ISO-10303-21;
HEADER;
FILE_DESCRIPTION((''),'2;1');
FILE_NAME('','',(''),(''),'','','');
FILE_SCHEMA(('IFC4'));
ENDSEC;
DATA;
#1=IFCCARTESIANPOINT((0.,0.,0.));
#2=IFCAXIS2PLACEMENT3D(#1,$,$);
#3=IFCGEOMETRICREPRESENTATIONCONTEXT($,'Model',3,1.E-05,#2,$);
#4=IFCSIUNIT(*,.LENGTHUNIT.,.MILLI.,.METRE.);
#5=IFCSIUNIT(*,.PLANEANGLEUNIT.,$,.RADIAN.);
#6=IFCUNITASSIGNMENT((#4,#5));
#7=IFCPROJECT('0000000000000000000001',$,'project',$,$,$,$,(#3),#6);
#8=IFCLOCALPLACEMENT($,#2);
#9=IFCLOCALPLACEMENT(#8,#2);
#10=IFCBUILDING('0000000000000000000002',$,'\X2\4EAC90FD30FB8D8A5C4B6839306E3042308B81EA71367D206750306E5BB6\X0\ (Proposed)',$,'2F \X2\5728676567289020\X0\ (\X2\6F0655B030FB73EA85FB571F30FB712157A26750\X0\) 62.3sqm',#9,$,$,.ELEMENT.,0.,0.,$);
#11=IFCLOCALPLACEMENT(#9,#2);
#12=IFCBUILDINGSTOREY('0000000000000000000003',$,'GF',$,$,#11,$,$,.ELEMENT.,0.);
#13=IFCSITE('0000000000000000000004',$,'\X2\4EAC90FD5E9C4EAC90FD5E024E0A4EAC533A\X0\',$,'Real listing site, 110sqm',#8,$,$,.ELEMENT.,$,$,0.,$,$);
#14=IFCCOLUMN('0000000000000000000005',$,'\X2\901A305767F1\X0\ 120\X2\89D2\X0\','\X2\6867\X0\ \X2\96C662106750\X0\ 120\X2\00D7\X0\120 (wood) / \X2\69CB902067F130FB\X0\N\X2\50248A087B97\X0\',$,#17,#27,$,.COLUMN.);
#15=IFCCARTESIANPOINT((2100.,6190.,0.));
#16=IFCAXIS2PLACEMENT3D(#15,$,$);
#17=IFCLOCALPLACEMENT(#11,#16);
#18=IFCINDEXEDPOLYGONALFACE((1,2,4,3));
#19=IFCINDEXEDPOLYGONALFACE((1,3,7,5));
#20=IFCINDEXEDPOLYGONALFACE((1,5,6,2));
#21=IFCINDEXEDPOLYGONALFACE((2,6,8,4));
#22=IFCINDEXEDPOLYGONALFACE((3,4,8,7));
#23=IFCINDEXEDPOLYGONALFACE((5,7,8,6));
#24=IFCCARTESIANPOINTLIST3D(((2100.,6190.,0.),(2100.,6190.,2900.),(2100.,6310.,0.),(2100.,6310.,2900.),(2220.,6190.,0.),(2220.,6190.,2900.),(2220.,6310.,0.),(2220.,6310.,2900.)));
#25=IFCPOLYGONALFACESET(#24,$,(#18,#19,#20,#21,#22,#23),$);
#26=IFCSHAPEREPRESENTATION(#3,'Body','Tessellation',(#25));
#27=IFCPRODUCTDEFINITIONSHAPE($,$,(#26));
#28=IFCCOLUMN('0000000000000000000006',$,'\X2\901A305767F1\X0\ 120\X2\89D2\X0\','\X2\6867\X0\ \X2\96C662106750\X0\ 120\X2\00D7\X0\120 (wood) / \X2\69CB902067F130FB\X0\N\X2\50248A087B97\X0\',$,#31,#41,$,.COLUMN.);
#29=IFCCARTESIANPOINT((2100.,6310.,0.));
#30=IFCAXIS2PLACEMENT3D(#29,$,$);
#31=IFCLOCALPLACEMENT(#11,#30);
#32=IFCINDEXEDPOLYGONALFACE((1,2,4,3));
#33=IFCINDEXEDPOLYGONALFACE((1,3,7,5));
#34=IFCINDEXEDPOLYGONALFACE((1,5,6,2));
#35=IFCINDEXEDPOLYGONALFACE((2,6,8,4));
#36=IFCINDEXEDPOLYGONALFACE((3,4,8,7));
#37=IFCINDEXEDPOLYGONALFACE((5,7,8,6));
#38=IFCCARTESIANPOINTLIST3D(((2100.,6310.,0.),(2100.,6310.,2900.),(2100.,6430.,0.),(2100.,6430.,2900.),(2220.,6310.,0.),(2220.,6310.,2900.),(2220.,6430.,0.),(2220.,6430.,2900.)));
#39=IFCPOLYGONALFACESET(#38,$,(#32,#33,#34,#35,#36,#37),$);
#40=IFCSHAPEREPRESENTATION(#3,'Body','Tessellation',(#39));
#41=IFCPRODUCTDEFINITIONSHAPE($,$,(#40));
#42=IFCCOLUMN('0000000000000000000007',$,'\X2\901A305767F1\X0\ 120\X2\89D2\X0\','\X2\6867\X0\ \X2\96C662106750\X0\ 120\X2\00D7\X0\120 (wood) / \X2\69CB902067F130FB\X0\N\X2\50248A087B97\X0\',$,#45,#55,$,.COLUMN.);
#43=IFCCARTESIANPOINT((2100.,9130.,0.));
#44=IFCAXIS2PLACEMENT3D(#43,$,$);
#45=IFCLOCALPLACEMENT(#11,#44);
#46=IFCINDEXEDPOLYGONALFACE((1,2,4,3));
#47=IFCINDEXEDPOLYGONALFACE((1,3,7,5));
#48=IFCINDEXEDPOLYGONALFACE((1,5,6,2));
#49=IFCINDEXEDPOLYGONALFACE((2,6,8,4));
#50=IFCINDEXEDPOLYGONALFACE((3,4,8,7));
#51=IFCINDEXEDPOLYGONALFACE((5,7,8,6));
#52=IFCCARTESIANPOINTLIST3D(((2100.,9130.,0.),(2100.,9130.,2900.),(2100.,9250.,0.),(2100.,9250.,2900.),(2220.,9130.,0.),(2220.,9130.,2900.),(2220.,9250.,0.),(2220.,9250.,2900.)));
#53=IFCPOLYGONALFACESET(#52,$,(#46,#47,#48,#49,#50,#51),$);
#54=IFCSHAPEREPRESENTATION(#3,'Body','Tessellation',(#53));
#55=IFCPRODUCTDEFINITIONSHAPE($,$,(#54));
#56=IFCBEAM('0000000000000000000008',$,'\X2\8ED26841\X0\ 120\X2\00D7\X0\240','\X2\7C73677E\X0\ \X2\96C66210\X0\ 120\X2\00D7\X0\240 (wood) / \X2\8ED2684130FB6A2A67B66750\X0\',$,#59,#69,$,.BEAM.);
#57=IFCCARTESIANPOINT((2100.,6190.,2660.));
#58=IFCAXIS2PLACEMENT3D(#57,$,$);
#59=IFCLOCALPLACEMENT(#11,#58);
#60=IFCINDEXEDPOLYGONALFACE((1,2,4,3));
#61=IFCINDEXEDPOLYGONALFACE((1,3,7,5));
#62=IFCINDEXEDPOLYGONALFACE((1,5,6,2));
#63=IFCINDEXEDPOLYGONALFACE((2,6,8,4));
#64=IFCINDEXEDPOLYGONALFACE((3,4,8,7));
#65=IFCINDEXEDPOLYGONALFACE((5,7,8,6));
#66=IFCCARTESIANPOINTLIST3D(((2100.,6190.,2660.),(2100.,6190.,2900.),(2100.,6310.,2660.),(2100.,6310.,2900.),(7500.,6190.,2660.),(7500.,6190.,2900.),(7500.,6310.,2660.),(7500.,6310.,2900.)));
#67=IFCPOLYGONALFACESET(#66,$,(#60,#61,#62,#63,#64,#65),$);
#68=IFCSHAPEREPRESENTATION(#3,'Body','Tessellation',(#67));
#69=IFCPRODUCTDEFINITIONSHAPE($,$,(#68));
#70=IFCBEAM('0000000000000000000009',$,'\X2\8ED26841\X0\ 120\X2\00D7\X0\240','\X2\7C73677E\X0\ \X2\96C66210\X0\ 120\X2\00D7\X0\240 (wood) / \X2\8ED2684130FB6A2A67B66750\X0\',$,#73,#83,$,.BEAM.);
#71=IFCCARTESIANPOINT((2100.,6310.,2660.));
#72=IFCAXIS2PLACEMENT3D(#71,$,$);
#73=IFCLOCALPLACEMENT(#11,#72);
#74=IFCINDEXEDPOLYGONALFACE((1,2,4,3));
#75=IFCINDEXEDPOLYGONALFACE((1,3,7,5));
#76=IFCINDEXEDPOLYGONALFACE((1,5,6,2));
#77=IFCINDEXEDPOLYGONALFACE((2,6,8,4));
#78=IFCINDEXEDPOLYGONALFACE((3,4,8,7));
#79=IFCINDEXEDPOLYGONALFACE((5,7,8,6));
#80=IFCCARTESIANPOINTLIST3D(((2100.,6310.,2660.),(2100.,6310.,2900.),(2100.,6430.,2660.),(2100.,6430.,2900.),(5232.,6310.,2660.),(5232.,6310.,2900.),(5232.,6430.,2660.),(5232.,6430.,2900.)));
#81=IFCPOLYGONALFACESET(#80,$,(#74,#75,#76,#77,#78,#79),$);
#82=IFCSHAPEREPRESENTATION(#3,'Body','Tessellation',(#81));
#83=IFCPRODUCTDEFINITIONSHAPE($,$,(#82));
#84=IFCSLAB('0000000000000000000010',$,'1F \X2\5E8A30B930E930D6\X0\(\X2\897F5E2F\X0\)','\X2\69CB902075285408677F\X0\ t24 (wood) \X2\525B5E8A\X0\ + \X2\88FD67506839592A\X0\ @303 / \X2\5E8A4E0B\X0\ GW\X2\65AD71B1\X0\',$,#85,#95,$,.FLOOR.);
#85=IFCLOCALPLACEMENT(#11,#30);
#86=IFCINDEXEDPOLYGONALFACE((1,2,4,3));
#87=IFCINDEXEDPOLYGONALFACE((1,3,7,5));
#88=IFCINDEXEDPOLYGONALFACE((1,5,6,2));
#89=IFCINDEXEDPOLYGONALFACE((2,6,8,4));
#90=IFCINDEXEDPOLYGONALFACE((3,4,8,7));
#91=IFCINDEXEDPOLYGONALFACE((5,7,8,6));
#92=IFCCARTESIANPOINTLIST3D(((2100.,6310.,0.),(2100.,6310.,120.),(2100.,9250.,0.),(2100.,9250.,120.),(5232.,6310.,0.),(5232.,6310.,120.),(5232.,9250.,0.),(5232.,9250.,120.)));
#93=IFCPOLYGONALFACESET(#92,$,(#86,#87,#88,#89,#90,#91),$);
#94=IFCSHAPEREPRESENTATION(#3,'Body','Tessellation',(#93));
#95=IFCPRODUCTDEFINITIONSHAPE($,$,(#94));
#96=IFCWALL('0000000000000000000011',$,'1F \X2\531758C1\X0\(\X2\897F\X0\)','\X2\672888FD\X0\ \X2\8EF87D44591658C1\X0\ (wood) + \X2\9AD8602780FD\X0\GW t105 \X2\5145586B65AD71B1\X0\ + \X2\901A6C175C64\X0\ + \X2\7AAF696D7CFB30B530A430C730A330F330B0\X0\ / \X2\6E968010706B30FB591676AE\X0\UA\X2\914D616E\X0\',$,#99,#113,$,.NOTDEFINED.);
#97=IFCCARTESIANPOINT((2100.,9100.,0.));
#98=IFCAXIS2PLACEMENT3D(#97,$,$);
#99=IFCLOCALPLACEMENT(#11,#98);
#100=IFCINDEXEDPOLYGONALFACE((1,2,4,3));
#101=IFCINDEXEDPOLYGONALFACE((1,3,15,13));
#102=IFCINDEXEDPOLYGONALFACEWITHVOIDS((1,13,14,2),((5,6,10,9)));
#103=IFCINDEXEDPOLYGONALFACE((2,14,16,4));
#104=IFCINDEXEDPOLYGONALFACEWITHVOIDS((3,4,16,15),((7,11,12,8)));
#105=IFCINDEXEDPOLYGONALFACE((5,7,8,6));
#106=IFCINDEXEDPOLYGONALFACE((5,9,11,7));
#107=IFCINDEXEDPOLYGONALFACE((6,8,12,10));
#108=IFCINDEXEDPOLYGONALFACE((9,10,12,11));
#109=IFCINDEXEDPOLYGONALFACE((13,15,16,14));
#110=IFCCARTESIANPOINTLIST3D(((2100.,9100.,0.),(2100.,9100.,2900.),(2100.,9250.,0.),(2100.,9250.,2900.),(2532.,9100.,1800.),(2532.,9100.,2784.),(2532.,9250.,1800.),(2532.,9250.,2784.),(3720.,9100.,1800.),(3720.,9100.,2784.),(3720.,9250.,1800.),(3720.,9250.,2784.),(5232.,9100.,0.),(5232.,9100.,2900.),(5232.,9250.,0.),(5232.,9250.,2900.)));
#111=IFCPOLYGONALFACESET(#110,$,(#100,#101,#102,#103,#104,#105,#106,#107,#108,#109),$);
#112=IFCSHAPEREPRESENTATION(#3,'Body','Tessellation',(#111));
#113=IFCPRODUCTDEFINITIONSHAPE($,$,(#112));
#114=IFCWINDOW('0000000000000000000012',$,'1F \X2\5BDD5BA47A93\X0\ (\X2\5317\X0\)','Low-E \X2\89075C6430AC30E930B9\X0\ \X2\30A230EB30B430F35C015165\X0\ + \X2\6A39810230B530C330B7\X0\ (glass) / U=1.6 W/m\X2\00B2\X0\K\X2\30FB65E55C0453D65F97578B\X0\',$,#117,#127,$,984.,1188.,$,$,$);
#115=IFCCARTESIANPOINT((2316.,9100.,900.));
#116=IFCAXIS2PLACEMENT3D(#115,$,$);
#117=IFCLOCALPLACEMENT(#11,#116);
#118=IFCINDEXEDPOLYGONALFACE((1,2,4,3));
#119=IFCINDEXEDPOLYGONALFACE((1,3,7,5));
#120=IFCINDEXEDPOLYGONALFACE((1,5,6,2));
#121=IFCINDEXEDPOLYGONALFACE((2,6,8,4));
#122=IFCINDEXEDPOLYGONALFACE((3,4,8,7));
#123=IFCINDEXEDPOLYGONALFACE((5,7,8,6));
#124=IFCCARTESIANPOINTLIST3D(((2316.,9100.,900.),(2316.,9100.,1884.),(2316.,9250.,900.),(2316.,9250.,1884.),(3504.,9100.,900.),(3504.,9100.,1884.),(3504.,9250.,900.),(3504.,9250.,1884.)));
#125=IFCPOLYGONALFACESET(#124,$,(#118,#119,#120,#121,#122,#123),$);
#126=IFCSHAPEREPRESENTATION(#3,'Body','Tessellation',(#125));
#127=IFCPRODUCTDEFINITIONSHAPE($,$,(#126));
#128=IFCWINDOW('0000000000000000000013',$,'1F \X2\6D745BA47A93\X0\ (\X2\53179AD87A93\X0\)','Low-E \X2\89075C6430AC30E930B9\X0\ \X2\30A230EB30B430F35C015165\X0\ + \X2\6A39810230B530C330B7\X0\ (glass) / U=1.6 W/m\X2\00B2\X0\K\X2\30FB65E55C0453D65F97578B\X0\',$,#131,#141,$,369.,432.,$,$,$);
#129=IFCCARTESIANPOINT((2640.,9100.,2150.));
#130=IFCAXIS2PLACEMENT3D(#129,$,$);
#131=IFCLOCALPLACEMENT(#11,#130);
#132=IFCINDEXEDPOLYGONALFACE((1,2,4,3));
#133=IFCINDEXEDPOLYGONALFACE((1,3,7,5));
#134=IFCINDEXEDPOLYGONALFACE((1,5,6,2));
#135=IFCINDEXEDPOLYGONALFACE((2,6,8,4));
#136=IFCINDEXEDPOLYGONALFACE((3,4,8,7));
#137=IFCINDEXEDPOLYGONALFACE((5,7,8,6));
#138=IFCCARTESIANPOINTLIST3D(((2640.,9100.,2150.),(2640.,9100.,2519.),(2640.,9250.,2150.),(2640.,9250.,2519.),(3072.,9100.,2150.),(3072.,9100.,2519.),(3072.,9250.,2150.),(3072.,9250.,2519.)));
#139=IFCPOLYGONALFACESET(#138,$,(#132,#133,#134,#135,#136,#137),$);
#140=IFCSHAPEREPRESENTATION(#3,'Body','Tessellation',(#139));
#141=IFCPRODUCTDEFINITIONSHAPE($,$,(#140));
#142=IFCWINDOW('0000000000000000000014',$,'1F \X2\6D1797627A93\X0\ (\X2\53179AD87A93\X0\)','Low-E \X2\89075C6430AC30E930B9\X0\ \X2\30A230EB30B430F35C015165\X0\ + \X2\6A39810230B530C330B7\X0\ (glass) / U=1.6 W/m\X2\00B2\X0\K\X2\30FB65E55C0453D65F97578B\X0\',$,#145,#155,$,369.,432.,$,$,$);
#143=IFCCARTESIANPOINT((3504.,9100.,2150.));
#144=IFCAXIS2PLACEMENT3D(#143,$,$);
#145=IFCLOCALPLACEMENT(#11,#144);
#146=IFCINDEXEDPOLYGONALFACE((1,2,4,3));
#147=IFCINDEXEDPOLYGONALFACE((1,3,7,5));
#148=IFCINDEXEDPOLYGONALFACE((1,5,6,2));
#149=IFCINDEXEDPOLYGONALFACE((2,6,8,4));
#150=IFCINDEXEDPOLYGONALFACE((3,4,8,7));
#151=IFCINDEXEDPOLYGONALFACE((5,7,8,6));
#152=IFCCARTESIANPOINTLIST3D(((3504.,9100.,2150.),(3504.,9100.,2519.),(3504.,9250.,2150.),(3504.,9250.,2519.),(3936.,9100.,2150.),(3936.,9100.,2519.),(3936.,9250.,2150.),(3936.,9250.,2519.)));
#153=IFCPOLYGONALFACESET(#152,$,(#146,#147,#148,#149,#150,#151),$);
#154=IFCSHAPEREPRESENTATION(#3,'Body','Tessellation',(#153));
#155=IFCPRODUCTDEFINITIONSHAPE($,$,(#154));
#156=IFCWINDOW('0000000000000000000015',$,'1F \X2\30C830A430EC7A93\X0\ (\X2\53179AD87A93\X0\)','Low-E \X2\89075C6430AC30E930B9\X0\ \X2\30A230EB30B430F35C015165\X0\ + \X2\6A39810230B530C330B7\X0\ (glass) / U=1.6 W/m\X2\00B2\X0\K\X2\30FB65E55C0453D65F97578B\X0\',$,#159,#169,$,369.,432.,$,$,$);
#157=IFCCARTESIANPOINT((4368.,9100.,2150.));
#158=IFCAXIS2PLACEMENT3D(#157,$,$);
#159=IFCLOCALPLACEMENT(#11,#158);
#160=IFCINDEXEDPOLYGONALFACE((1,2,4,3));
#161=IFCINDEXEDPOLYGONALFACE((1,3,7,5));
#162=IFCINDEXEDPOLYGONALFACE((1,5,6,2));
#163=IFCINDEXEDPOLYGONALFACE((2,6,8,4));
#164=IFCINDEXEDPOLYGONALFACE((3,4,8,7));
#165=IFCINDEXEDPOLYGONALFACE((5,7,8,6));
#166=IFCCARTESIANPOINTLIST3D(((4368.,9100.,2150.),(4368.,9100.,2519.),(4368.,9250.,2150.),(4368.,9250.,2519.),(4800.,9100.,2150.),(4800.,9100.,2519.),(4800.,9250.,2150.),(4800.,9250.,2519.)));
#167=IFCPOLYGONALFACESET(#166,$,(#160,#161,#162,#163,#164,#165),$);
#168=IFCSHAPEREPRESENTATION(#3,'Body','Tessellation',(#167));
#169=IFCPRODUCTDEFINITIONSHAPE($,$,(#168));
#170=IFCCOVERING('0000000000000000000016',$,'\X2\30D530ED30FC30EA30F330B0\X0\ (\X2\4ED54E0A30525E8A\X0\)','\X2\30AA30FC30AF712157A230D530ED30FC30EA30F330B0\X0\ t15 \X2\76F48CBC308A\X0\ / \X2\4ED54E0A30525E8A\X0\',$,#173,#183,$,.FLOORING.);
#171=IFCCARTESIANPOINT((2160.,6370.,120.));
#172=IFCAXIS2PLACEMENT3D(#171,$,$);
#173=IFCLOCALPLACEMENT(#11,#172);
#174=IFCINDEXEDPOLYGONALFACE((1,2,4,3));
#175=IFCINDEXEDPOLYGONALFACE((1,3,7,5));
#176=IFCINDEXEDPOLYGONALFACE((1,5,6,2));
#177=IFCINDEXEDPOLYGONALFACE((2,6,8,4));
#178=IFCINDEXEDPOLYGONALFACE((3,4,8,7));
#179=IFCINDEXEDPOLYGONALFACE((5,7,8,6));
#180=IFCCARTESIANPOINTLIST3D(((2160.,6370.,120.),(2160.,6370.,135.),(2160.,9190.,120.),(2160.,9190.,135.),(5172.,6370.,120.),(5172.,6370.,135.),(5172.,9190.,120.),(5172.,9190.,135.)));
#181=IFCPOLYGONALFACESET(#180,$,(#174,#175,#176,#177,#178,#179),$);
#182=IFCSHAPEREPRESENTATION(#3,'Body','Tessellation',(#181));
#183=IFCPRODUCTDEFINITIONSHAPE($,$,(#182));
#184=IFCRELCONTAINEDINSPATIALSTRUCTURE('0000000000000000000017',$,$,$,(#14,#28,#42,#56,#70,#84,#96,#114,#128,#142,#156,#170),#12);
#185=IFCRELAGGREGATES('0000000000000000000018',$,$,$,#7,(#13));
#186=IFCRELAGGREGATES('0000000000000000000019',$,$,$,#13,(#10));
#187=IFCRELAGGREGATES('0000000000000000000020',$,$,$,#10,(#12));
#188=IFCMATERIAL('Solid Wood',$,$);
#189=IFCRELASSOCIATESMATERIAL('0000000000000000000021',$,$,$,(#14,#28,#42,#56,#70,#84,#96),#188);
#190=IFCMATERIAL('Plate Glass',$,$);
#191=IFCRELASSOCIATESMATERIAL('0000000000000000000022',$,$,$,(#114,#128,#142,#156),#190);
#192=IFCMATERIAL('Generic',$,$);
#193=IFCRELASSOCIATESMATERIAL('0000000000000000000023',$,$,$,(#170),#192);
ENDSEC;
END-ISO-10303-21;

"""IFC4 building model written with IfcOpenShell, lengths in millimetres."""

from ifc_helpers import new_model, si_unit, frame, frame_2d, origin, place, context, project, spatial, rectangle, extrude, material, element, fill, save


model = new_model("IFC4")

# Units and contexts
model_context = context("Model", 3, precision=1e-05, world=origin())
ifc_project = project(units=[si_unit("LENGTHUNIT", "METRE", prefix="MILLI"), si_unit("PLANEANGLEUNIT", "RADIAN")], contexts=[model_context])

# Site, building, storey
site_placement = place(None, origin())
site = spatial("IfcSite", under=ifc_project, at=site_placement, Name="京都府京都市上京区", ObjectType="Real listing site, 110sqm", CompositionType="ELEMENT", RefElevation=0.0)
building_placement = place(site_placement, origin())
building = spatial("IfcBuilding", under=site, at=building_placement, Name="京都・越屋根のある自然素材の家 (Proposed)", ObjectType="2F 在来木造 (漆喰・珪藻土・無垢材) 62.3sqm", CompositionType="ELEMENT", ElevationOfRefHeight=0.0, ElevationOfTerrain=0.0)
storey_placement = place(building_placement, origin())
storey = spatial("IfcBuildingStorey", under=building, at=storey_placement, Name="GF", CompositionType="ELEMENT", Elevation=0.0)

# Columns
ifc_material_1 = material(Name="Solid Wood")
column_1_placement = place(storey_placement, frame((2100.0, 6190.0, 0.0)))
element("IfcColumn", 1, at=column_1_placement, inside=storey, material=ifc_material_1, Name="通し柱 120角", Description="桧 集成材 120×120 (wood) / 構造柱・N値計算", PredefinedType="COLUMN", context=model_context, shape_type="SweptSolid", body=[
    extrude(rectangle(XDim=120.0, YDim=120.0, at=frame_2d((60.0, 60.0))), frame((2100.0, 6190.0, 0.0)), (0.0, 0.0, 1.0), 2900.0),
])
column_2_placement = place(storey_placement, frame((2100.0, 6310.0, 0.0)))
element("IfcColumn", 2, at=column_2_placement, inside=storey, material=ifc_material_1, Name="通し柱 120角", Description="桧 集成材 120×120 (wood) / 構造柱・N値計算", PredefinedType="COLUMN", context=model_context, shape_type="SweptSolid", body=[
    extrude(rectangle(XDim=120.0, YDim=120.0, at=frame_2d((60.0, 60.0))), frame((2100.0, 6310.0, 0.0)), (0.0, 0.0, 1.0), 2900.0),
])
column_3_placement = place(storey_placement, frame((2100.0, 9130.0, 0.0)))
element("IfcColumn", 3, at=column_3_placement, inside=storey, material=ifc_material_1, Name="通し柱 120角", Description="桧 集成材 120×120 (wood) / 構造柱・N値計算", PredefinedType="COLUMN", context=model_context, shape_type="SweptSolid", body=[
    extrude(rectangle(XDim=120.0, YDim=120.0, at=frame_2d((60.0, 60.0))), frame((2100.0, 9130.0, 0.0)), (0.0, 0.0, 1.0), 2900.0),
])

# Beams
beam_1_placement = place(storey_placement, frame((2100.0, 6190.0, 2660.0)))
element("IfcBeam", 4, at=beam_1_placement, inside=storey, material=ifc_material_1, Name="軒桁 120×240", Description="米松 集成 120×240 (wood) / 軒桁・横架材", PredefinedType="BEAM", context=model_context, shape_type="SweptSolid", body=[
    extrude(rectangle(XDim=5400.0, YDim=120.0, at=frame_2d((2700.0, 60.0))), frame((2100.0, 6190.0, 2660.0)), (0.0, 0.0, 1.0), 240.0),
])
beam_2_placement = place(storey_placement, frame((2100.0, 6310.0, 2660.0)))
element("IfcBeam", 5, at=beam_2_placement, inside=storey, material=ifc_material_1, Name="軒桁 120×240", Description="米松 集成 120×240 (wood) / 軒桁・横架材", PredefinedType="BEAM", context=model_context, shape_type="SweptSolid", body=[
    extrude(rectangle(XDim=3132.0, YDim=120.0, at=frame_2d((1566.0, 60.0))), frame((2100.0, 6310.0, 2660.0)), (0.0, 0.0, 1.0), 240.0),
])

# Slab
slab_placement = place(storey_placement, frame((2100.0, 6310.0, 0.0)))
element("IfcSlab", 6, at=slab_placement, inside=storey, material=ifc_material_1, Name="1F 床スラブ(西帯)", Description="構造用合板 t24 (wood) 剛床 + 製材根太 @303 / 床下 GW断熱", PredefinedType="FLOOR", context=model_context, shape_type="SweptSolid", body=[
    extrude(rectangle(XDim=3132.0, YDim=2940.0, at=frame_2d((1566.0, 1470.0))), frame((2100.0, 6310.0, 0.0)), (0.0, 0.0, 1.0), 120.0),
])

# Wall, openings, windows
wall_1_placement = place(storey_placement, frame((2100.0, 9100.0, 0.0)))
wall_1 = element("IfcWall", 7, at=wall_1_placement, inside=storey, material=ifc_material_1, Name="1F 北壁(西)", Description="木製 軸組外壁 (wood) + 高性能GW t105 充填断熱 + 通気層 + 窯業系サイディング / 準耐火・外皮UA配慮", PredefinedType="NOTDEFINED", context=model_context, shape_type="SweptSolid", body=[
    extrude(rectangle(XDim=3132.0, YDim=150.0, at=frame_2d((1566.0, 75.0))), frame((2100.0, 9100.0, 0.0)), (0.0, 0.0, 1.0), 2900.0),
])
opening_1_placement = place(storey_placement, frame((2316.0, 9100.0, 900.0)))
opening_1 = element("IfcOpeningElement", 8, at=opening_1_placement, cuts=wall_1, PredefinedType="NOTDEFINED", context=model_context, shape_type="SweptSolid", body=[
    extrude(rectangle(XDim=1188.0, YDim=150.0, at=frame_2d((594.0, 75.0))), frame((2316.0, 9100.0, 900.0)), (0.0, 0.0, 1.0), 984.0),
])
opening_2_placement = place(storey_placement, frame((2640.0, 9100.0, 2150.0)))
opening_2 = element("IfcOpeningElement", 9, at=opening_2_placement, cuts=wall_1, PredefinedType="NOTDEFINED", context=model_context, shape_type="SweptSolid", body=[
    extrude(rectangle(XDim=432.0, YDim=150.0, at=frame_2d((216.0, 75.0))), frame((2640.0, 9100.0, 2150.0)), (0.0, 0.0, 1.0), 369.0),
])
opening_3_placement = place(storey_placement, frame((3504.0, 9100.0, 2150.0)))
opening_3 = element("IfcOpeningElement", 10, at=opening_3_placement, cuts=wall_1, PredefinedType="NOTDEFINED", context=model_context, shape_type="SweptSolid", body=[
    extrude(rectangle(XDim=432.0, YDim=150.0, at=frame_2d((216.0, 75.0))), frame((3504.0, 9100.0, 2150.0)), (0.0, 0.0, 1.0), 369.0),
])
opening_4_placement = place(storey_placement, frame((4368.0, 9100.0, 2150.0)))
opening_4 = element("IfcOpeningElement", 11, at=opening_4_placement, cuts=wall_1, PredefinedType="NOTDEFINED", context=model_context, shape_type="SweptSolid", body=[
    extrude(rectangle(XDim=432.0, YDim=150.0, at=frame_2d((216.0, 75.0))), frame((4368.0, 9100.0, 2150.0)), (0.0, 0.0, 1.0), 369.0),
])
ifc_material_2 = material(Name="Plate Glass")
window_1_placement = place(storey_placement, frame((2316.0, 9100.0, 900.0)))
window_1 = element("IfcWindow", 12, at=window_1_placement, inside=storey, material=ifc_material_2, Name="1F 寝室窓 (北)", Description="Low-E 複層ガラス アルゴン封入 + 樹脂サッシ (glass) / U=1.6 W/m²K・日射取得型", OverallHeight=984.0, OverallWidth=1188.0, context=model_context, shape_type="SweptSolid", body=[
    extrude(rectangle(XDim=1188.0, YDim=150.0, at=frame_2d((594.0, 75.0))), frame((2316.0, 9100.0, 900.0)), (0.0, 0.0, 1.0), 984.0),
])
fill(opening_1, window_1)
window_2_placement = place(storey_placement, frame((2640.0, 9100.0, 2150.0)))
window_2 = element("IfcWindow", 13, at=window_2_placement, inside=storey, material=ifc_material_2, Name="1F 浴室窓 (北高窓)", Description="Low-E 複層ガラス アルゴン封入 + 樹脂サッシ (glass) / U=1.6 W/m²K・日射取得型", OverallHeight=369.0, OverallWidth=432.0, context=model_context, shape_type="SweptSolid", body=[
    extrude(rectangle(XDim=432.0, YDim=150.0, at=frame_2d((216.0, 75.0))), frame((2640.0, 9100.0, 2150.0)), (0.0, 0.0, 1.0), 369.0),
])
fill(opening_2, window_2)
window_3_placement = place(storey_placement, frame((3504.0, 9100.0, 2150.0)))
window_3 = element("IfcWindow", 14, at=window_3_placement, inside=storey, material=ifc_material_2, Name="1F 洗面窓 (北高窓)", Description="Low-E 複層ガラス アルゴン封入 + 樹脂サッシ (glass) / U=1.6 W/m²K・日射取得型", OverallHeight=369.0, OverallWidth=432.0, context=model_context, shape_type="SweptSolid", body=[
    extrude(rectangle(XDim=432.0, YDim=150.0, at=frame_2d((216.0, 75.0))), frame((3504.0, 9100.0, 2150.0)), (0.0, 0.0, 1.0), 369.0),
])
fill(opening_3, window_3)
window_4_placement = place(storey_placement, frame((4368.0, 9100.0, 2150.0)))
window_4 = element("IfcWindow", 15, at=window_4_placement, inside=storey, material=ifc_material_2, Name="1F トイレ窓 (北高窓)", Description="Low-E 複層ガラス アルゴン封入 + 樹脂サッシ (glass) / U=1.6 W/m²K・日射取得型", OverallHeight=369.0, OverallWidth=432.0, context=model_context, shape_type="SweptSolid", body=[
    extrude(rectangle(XDim=432.0, YDim=150.0, at=frame_2d((216.0, 75.0))), frame((4368.0, 9100.0, 2150.0)), (0.0, 0.0, 1.0), 369.0),
])
fill(opening_4, window_4)

# Covering
ifc_material_3 = material(Name="Generic")
covering_placement = place(storey_placement, frame((2160.0, 6370.0, 120.0)))
element("IfcCovering", 16, at=covering_placement, inside=storey, material=ifc_material_3, Name="フローリング (仕上げ床)", Description="オーク無垢フローリング t15 直貼り / 仕上げ床", PredefinedType="FLOORING", context=model_context, shape_type="SweptSolid", body=[
    extrude(rectangle(XDim=3012.0, YDim=2820.0, at=frame_2d((1506.0, 1410.0))), frame((2160.0, 6370.0, 120.0)), (0.0, 0.0, 1.0), 15.0),
])

save(model, "model.ifc")
